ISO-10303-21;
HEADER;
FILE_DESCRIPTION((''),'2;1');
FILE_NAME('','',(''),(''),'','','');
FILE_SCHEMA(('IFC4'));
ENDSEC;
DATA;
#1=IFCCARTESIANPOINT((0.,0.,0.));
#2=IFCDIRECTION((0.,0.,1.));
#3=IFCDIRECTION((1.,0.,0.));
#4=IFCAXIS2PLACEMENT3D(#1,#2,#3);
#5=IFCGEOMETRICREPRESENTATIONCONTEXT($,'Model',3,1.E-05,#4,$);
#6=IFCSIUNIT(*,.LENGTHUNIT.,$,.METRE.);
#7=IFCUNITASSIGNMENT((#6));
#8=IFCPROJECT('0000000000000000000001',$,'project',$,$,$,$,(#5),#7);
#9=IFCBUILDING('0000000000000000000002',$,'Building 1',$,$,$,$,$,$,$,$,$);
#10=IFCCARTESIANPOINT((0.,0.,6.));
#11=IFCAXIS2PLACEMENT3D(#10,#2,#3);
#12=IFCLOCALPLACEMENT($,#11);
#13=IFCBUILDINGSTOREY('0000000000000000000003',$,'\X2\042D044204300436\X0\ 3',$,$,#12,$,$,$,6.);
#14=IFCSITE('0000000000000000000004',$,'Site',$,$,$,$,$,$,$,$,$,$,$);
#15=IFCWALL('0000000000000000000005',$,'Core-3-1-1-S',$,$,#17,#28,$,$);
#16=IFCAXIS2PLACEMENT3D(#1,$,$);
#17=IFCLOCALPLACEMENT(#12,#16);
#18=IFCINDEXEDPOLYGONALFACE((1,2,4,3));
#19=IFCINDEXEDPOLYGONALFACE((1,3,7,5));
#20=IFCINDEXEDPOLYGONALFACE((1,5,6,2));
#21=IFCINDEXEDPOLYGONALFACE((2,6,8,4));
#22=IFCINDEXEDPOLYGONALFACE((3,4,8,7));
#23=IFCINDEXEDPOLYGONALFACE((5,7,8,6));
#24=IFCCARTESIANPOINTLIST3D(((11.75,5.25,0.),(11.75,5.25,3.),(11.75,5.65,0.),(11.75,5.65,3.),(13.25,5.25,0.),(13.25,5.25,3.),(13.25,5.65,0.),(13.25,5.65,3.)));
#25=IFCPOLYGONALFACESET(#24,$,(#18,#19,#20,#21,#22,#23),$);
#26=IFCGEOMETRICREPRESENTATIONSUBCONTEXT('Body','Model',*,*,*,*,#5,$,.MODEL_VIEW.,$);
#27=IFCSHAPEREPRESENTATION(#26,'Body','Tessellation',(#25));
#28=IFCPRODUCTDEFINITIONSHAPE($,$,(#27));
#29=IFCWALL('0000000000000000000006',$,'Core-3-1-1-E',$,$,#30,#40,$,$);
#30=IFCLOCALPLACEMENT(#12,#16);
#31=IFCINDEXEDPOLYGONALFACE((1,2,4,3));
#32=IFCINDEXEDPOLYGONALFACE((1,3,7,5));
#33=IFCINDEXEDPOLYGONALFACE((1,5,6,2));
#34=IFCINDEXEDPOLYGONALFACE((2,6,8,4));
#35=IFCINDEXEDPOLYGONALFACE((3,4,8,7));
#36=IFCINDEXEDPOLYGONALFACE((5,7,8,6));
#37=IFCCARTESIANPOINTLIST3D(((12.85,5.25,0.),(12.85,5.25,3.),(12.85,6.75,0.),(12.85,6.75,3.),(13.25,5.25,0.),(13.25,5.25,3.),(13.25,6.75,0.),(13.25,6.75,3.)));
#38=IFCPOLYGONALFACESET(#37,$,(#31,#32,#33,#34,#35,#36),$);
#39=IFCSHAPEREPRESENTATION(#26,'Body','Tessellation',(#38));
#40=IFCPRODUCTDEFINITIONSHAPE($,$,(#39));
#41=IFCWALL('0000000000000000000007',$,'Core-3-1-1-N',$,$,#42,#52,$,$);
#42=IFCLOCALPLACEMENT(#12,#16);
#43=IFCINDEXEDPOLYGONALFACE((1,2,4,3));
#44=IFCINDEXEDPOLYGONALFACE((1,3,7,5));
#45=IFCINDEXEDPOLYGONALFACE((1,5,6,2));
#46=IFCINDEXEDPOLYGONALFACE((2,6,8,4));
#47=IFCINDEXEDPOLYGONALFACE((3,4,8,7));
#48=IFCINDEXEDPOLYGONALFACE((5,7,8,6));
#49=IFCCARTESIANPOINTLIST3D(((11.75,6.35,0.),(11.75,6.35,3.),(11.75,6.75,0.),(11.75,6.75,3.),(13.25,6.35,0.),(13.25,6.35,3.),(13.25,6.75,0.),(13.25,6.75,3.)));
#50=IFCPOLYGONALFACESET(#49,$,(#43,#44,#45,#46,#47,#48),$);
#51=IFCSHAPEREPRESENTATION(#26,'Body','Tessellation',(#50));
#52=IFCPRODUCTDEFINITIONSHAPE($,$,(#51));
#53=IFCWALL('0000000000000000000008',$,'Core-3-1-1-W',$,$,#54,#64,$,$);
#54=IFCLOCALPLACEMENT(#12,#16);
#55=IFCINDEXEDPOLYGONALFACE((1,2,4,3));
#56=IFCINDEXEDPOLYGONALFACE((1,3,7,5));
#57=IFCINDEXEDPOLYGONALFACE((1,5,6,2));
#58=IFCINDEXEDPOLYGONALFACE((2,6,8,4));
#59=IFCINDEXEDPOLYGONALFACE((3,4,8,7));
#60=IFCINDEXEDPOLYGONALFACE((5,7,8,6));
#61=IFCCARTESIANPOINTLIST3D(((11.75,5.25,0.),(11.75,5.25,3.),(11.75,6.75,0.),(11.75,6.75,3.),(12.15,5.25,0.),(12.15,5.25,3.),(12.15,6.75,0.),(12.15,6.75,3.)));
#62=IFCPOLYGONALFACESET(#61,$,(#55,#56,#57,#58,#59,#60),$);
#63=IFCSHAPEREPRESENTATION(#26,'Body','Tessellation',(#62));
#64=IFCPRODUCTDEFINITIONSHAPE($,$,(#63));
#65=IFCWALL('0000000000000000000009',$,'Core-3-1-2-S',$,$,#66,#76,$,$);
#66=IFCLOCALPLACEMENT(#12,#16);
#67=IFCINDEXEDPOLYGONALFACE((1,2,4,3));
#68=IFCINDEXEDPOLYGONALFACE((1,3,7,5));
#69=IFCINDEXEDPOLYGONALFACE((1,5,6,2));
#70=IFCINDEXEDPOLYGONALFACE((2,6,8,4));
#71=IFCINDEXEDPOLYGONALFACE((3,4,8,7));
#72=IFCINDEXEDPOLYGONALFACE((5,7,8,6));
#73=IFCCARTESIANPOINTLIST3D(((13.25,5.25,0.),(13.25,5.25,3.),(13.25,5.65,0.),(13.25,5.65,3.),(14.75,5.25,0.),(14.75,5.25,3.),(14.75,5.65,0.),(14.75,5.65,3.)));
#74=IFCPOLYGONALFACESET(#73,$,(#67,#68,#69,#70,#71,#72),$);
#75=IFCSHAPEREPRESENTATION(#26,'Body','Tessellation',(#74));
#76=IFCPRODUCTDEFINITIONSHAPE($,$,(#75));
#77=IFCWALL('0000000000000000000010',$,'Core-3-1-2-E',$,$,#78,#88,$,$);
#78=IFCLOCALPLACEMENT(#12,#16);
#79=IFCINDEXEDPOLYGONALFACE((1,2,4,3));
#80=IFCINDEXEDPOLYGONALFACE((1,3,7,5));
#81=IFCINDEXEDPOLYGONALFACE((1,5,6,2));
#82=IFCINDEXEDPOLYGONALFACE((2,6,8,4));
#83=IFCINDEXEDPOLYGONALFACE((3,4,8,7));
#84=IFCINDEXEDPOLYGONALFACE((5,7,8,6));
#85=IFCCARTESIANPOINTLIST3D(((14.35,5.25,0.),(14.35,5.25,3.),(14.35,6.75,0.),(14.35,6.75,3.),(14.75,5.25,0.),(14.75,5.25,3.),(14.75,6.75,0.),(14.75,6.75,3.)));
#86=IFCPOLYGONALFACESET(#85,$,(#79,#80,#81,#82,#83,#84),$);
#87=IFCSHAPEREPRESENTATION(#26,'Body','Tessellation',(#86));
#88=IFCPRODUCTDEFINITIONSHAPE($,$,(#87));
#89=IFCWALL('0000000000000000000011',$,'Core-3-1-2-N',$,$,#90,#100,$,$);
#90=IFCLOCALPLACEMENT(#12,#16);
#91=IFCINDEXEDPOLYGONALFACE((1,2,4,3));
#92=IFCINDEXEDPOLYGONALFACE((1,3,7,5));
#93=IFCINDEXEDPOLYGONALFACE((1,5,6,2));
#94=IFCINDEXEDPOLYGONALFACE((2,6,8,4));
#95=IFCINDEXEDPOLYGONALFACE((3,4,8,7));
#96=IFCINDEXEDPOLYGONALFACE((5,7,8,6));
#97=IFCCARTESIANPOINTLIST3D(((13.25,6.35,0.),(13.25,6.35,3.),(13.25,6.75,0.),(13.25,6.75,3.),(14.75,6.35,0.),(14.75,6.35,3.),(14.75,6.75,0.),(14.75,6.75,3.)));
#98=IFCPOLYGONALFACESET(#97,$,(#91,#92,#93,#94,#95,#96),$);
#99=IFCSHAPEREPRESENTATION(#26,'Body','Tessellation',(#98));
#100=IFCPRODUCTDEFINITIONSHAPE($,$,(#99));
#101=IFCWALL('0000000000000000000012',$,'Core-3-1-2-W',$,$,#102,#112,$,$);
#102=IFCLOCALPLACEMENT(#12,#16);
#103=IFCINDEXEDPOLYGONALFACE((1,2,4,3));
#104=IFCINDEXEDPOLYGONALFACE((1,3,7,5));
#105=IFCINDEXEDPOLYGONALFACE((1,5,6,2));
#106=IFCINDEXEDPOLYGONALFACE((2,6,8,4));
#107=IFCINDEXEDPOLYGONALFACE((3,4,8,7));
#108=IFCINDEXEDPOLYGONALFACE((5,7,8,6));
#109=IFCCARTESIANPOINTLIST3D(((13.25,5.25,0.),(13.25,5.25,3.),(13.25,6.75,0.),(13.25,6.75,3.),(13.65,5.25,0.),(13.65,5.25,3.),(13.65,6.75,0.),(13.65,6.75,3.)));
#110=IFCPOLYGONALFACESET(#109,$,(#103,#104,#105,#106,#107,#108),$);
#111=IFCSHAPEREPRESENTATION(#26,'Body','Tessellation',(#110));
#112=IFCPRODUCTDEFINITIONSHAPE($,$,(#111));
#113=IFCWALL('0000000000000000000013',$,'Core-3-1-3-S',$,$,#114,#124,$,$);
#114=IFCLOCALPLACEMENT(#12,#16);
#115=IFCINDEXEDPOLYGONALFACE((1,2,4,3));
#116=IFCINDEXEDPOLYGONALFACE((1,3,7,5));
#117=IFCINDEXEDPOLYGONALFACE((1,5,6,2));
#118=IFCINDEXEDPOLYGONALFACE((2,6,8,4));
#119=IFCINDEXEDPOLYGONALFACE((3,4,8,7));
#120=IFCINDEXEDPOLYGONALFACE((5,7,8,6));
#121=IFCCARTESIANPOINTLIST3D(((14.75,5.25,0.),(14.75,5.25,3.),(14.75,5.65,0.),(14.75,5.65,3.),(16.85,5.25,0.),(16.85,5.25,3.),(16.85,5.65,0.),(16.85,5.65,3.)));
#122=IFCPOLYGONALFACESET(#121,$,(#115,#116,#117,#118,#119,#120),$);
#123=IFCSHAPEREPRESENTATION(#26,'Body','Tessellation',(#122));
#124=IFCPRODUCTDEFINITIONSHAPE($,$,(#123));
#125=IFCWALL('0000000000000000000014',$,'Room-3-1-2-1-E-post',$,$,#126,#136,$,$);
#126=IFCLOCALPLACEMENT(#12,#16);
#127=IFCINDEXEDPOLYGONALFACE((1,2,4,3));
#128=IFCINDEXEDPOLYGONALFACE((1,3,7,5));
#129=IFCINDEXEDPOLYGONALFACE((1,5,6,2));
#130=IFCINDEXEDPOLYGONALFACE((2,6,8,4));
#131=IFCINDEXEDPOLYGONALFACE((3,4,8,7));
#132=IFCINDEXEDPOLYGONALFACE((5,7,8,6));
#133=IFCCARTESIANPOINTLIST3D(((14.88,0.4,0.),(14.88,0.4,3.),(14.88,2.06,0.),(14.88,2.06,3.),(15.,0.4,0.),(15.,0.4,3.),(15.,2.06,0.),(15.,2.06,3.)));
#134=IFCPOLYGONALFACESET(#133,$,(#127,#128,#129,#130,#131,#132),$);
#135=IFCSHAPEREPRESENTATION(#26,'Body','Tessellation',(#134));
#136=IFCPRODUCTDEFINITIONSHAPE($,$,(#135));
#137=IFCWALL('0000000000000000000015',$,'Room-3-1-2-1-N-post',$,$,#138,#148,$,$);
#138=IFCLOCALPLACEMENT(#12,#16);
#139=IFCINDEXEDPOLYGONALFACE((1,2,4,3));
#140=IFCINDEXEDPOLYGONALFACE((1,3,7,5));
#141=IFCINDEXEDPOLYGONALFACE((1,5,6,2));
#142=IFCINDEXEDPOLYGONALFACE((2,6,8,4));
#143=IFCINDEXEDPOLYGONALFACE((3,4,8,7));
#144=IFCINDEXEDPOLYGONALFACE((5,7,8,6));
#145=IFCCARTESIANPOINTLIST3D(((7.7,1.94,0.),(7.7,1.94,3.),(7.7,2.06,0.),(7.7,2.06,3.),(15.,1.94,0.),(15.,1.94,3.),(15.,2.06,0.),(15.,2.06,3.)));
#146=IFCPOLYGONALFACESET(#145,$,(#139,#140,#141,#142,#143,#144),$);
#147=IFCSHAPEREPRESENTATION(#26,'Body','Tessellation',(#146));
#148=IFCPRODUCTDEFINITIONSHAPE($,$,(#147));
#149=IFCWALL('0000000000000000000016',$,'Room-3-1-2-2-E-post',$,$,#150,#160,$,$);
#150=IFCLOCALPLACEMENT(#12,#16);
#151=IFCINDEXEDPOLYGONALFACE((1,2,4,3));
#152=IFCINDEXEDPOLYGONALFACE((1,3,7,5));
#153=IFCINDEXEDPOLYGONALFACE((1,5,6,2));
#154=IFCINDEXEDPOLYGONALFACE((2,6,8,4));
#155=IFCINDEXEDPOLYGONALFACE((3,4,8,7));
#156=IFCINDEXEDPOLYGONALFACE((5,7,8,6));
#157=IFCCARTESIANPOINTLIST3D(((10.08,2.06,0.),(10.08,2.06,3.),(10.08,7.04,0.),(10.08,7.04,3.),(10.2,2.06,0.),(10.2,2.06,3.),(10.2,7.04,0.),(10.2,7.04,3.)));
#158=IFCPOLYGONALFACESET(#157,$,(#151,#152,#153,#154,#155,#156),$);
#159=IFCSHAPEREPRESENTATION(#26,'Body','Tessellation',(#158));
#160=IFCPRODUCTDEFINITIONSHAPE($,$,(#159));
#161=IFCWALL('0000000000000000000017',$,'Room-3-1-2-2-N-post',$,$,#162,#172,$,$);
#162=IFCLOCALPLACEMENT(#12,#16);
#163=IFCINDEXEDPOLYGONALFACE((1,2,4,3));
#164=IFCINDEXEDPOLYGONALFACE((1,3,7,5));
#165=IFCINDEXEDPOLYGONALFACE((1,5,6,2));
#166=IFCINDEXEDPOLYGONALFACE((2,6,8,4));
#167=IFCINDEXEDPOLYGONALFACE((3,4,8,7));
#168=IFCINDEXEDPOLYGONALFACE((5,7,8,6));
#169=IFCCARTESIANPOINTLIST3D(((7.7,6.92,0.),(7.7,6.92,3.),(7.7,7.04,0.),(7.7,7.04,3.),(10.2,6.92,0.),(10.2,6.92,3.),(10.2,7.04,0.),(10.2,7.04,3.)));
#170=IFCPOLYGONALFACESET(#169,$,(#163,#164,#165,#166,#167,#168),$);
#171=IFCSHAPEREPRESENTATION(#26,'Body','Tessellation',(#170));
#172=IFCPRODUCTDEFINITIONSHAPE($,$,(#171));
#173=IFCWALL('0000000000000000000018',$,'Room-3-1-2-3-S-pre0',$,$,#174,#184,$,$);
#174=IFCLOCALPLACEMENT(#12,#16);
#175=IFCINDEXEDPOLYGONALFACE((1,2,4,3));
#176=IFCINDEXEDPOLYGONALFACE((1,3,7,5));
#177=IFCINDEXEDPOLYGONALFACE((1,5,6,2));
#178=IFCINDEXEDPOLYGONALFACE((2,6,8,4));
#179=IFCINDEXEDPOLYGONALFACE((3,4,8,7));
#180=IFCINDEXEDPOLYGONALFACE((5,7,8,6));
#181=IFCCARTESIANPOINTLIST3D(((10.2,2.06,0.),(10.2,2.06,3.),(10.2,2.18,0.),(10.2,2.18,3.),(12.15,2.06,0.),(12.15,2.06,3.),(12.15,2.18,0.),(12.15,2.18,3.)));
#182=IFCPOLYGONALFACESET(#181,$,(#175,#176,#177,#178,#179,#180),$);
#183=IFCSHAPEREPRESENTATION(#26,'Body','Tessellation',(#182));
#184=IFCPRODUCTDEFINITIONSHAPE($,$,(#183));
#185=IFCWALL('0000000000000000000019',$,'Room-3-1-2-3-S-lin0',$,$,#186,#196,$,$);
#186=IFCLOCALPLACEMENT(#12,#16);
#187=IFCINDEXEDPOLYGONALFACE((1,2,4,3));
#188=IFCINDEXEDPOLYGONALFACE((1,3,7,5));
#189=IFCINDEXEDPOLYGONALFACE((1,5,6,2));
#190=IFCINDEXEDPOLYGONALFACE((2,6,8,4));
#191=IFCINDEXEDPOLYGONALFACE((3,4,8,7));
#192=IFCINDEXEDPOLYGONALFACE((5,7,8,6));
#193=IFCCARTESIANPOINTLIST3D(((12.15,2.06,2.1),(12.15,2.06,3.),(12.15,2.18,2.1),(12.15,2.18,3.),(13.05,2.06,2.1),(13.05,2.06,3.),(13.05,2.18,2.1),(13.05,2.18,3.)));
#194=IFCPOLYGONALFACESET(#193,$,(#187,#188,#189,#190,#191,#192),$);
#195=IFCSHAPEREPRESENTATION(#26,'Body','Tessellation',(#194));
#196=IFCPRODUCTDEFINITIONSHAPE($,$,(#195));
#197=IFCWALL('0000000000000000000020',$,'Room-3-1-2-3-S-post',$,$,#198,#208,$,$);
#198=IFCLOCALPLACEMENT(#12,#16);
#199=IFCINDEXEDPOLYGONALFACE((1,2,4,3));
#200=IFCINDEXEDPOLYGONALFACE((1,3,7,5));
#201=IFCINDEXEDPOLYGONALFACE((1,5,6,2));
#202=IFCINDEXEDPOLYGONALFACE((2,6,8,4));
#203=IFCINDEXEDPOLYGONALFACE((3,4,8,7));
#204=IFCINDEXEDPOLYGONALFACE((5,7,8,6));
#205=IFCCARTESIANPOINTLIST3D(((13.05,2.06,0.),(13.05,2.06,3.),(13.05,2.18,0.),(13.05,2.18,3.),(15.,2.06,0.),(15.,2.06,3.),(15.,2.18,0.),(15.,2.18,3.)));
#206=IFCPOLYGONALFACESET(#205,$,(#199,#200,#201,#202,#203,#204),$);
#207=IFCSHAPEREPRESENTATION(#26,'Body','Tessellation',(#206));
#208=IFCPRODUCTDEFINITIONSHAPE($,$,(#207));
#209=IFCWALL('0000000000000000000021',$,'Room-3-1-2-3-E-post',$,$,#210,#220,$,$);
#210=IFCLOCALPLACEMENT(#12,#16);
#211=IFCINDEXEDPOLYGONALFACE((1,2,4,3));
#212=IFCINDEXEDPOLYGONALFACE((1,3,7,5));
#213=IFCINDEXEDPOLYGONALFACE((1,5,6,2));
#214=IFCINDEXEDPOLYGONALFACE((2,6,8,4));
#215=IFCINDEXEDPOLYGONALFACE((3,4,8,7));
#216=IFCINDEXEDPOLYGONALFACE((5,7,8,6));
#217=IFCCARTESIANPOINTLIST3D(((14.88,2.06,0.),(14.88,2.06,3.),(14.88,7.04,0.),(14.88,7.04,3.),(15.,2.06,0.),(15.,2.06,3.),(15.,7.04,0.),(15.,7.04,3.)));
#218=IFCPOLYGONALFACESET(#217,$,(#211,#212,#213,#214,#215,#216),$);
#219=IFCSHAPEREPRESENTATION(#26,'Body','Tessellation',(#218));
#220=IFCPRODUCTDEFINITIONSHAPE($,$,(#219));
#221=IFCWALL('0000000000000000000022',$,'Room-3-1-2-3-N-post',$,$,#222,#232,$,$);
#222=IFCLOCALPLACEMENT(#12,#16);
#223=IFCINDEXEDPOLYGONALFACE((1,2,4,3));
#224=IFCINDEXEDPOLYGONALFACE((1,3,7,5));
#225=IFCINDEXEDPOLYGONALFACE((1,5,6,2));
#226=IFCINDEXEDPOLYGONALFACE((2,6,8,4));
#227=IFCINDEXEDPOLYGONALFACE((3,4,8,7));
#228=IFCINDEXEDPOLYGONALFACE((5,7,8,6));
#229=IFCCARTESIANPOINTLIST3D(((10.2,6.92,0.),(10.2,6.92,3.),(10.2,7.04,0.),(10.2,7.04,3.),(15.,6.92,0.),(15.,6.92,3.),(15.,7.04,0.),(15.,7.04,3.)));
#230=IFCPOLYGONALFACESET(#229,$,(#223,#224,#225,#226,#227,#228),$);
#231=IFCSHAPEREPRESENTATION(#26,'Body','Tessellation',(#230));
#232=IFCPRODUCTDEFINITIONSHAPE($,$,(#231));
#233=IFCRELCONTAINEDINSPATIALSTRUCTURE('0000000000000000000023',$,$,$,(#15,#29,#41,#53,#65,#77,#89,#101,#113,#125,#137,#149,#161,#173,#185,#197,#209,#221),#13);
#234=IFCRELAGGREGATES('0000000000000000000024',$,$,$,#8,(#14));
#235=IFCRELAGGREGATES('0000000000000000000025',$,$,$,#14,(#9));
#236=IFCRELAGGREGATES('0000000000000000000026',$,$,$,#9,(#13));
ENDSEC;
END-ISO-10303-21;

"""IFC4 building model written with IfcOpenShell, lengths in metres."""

from ifc_helpers import new_model, si_unit, frame, origin_with_axes, place, context, subcontext, project, spatial, indexed_curve, outline, extrude, element, save


model = new_model("IFC4")

# Units and contexts
model_context = context("Model", 3, precision=1e-05, world=origin_with_axes())
body_context = subcontext(model_context, "Body", "Model", "MODEL_VIEW")
ifc_project = project(units=[si_unit("LENGTHUNIT", "METRE")], contexts=[model_context])

# Site, building, storey
site = spatial("IfcSite", under=ifc_project, Name="Site")
building = spatial("IfcBuilding", under=site, Name="Building 1")
storey_placement = place(None, frame((0.0, 0.0, 6.0), z_axis=(0.0, 0.0, 1.0), x_axis=(1.0, 0.0, 0.0)))
storey = spatial("IfcBuildingStorey", under=building, at=storey_placement, Name="Этаж 3", Elevation=6.0)

# Walls
for number, where, z_axis, x_axis, name in (
    (1, (11.75, 5.25, 0.0), (0.0, 0.0, 1.0), (1.0, 0.0, 0.0), "Core-3-1-1-S"),
    (2, (13.25, 5.25, 0.0), (0.0, 0.0, 1.0), (0.0, 1.0, 0.0), "Core-3-1-1-E"),
    (3, (13.25, 6.75, 0.0), (0.0, 0.0, 1.0), (-1.0, 0.0, 0.0), "Core-3-1-1-N"),
    (4, (11.75, 6.75, 0.0), (0.0, 0.0, 1.0), (0.0, -1.0, 0.0), "Core-3-1-1-W"),
    (5, (13.25, 5.25, 0.0), (0.0, 0.0, 1.0), (1.0, 0.0, 0.0), "Core-3-1-2-S"),
    (6, (14.75, 5.25, 0.0), (0.0, 0.0, 1.0), (0.0, 1.0, 0.0), "Core-3-1-2-E"),
    (7, (14.75, 6.75, 0.0), (0.0, 0.0, 1.0), (-1.0, 0.0, 0.0), "Core-3-1-2-N"),
    (8, (13.25, 6.75, 0.0), (0.0, 0.0, 1.0), (0.0, -1.0, 0.0), "Core-3-1-2-W"),
):
    element("IfcWall", number, at=place(storey_placement, frame(where, z_axis=z_axis, x_axis=x_axis)), inside=storey, Name=name, context=body_context, shape_type="SweptSolid", body=[
        extrude(outline(indexed_curve([(0.0, 0.0), (0.0, 0.4), (1.5, 0.4), (1.5, 0.0), (0.0, 0.0)], self_intersect=False)), origin_with_axes(), (0.0, 0.0, 1.0), 3.0),
    ])
wall_1_placement = place(storey_placement, frame((14.75, 5.25, 0.0), z_axis=(0.0, 0.0, 1.0), x_axis=(1.0, 0.0, 0.0)))
element("IfcWall", 9, at=wall_1_placement, inside=storey, Name="Core-3-1-3-S", context=body_context, shape_type="SweptSolid", body=[
    extrude(outline(indexed_curve([(0.0, 0.0), (0.0, 0.4), (2.1, 0.4), (2.1, 0.0), (0.0, 0.0)], self_intersect=False)), origin_with_axes(), (0.0, 0.0, 1.0), 3.0),
])
wall_2_placement = place(storey_placement, frame((15.0, 0.4, 0.0), z_axis=(0.0, 0.0, 1.0), x_axis=(0.0, 1.0, 0.0)))
element("IfcWall", 10, at=wall_2_placement, inside=storey, Name="Room-3-1-2-1-E-post", context=body_context, shape_type="SweptSolid", body=[
    extrude(outline(indexed_curve([(0.0, 0.0), (0.0, 0.12), (1.66, 0.12), (1.66, 0.0), (0.0, 0.0)], self_intersect=False)), origin_with_axes(), (0.0, 0.0, 1.0), 3.0),
])
wall_3_placement = place(storey_placement, frame((15.0, 2.06, 0.0), z_axis=(0.0, 0.0, 1.0), x_axis=(-1.0, 0.0, 0.0)))
element("IfcWall", 11, at=wall_3_placement, inside=storey, Name="Room-3-1-2-1-N-post", context=body_context, shape_type="SweptSolid", body=[
    extrude(outline(indexed_curve([(0.0, 0.0), (0.0, 0.12), (7.3, 0.12), (7.3, 0.0), (0.0, 0.0)], self_intersect=False)), origin_with_axes(), (0.0, 0.0, 1.0), 3.0),
])
wall_4_placement = place(storey_placement, frame((10.2, 2.06, 0.0), z_axis=(0.0, 0.0, 1.0), x_axis=(0.0, 1.0, 0.0)))
element("IfcWall", 12, at=wall_4_placement, inside=storey, Name="Room-3-1-2-2-E-post", context=body_context, shape_type="SweptSolid", body=[
    extrude(outline(indexed_curve([(0.0, 0.0), (0.0, 0.12), (4.98, 0.12), (4.98, 0.0), (0.0, 0.0)], self_intersect=False)), origin_with_axes(), (0.0, 0.0, 1.0), 3.0),
])
wall_5_placement = place(storey_placement, frame((10.2, 7.04, 0.0), z_axis=(0.0, 0.0, 1.0), x_axis=(-1.0, 0.0, 0.0)))
element("IfcWall", 13, at=wall_5_placement, inside=storey, Name="Room-3-1-2-2-N-post", context=body_context, shape_type="SweptSolid", body=[
    extrude(outline(indexed_curve([(0.0, 0.0), (0.0, 0.12), (2.5, 0.12), (2.5, 0.0), (0.0, 0.0)], self_intersect=False)), origin_with_axes(), (0.0, 0.0, 1.0), 3.0),
])
wall_6_placement = place(storey_placement, frame((10.2, 2.06, 0.0), z_axis=(0.0, 0.0, 1.0), x_axis=(1.0, 0.0, 0.0)))
element("IfcWall", 14, at=wall_6_placement, inside=storey, Name="Room-3-1-2-3-S-pre0", context=body_context, shape_type="SweptSolid", body=[
    extrude(outline(indexed_curve([(0.0, 0.0), (0.0, 0.12), (1.95, 0.12), (1.95, 0.0), (0.0, 0.0)], self_intersect=False)), origin_with_axes(), (0.0, 0.0, 1.0), 3.0),
])
wall_7_placement = place(storey_placement, frame((12.15, 2.06, 2.1), z_axis=(0.0, 0.0, 1.0), x_axis=(1.0, 0.0, 0.0)))
element("IfcWall", 15, at=wall_7_placement, inside=storey, Name="Room-3-1-2-3-S-lin0", context=body_context, shape_type="SweptSolid", body=[
    extrude(outline(indexed_curve([(0.0, 0.0), (0.0, 0.12), (0.9, 0.12), (0.9, 0.0), (0.0, 0.0)], self_intersect=False)), origin_with_axes(), (0.0, 0.0, 1.0), 0.9),
])
wall_8_placement = place(storey_placement, frame((13.05, 2.06, 0.0), z_axis=(0.0, 0.0, 1.0), x_axis=(1.0, 0.0, 0.0)))
element("IfcWall", 16, at=wall_8_placement, inside=storey, Name="Room-3-1-2-3-S-post", context=body_context, shape_type="SweptSolid", body=[
    extrude(outline(indexed_curve([(0.0, 0.0), (0.0, 0.12), (1.95, 0.12), (1.95, 0.0), (0.0, 0.0)], self_intersect=False)), origin_with_axes(), (0.0, 0.0, 1.0), 3.0),
])
wall_9_placement = place(storey_placement, frame((15.0, 2.06, 0.0), z_axis=(0.0, 0.0, 1.0), x_axis=(0.0, 1.0, 0.0)))
element("IfcWall", 17, at=wall_9_placement, inside=storey, Name="Room-3-1-2-3-E-post", context=body_context, shape_type="SweptSolid", body=[
    extrude(outline(indexed_curve([(0.0, 0.0), (0.0, 0.12), (4.98, 0.12), (4.98, 0.0), (0.0, 0.0)], self_intersect=False)), origin_with_axes(), (0.0, 0.0, 1.0), 3.0),
])
wall_10_placement = place(storey_placement, frame((15.0, 7.04, 0.0), z_axis=(0.0, 0.0, 1.0), x_axis=(-1.0, 0.0, 0.0)))
element("IfcWall", 18, at=wall_10_placement, inside=storey, Name="Room-3-1-2-3-N-post", context=body_context, shape_type="SweptSolid", body=[
    extrude(outline(indexed_curve([(0.0, 0.0), (0.0, 0.12), (4.8, 0.12), (4.8, 0.0), (0.0, 0.0)], self_intersect=False)), origin_with_axes(), (0.0, 0.0, 1.0), 3.0),
])

save(model, "model.ifc")
